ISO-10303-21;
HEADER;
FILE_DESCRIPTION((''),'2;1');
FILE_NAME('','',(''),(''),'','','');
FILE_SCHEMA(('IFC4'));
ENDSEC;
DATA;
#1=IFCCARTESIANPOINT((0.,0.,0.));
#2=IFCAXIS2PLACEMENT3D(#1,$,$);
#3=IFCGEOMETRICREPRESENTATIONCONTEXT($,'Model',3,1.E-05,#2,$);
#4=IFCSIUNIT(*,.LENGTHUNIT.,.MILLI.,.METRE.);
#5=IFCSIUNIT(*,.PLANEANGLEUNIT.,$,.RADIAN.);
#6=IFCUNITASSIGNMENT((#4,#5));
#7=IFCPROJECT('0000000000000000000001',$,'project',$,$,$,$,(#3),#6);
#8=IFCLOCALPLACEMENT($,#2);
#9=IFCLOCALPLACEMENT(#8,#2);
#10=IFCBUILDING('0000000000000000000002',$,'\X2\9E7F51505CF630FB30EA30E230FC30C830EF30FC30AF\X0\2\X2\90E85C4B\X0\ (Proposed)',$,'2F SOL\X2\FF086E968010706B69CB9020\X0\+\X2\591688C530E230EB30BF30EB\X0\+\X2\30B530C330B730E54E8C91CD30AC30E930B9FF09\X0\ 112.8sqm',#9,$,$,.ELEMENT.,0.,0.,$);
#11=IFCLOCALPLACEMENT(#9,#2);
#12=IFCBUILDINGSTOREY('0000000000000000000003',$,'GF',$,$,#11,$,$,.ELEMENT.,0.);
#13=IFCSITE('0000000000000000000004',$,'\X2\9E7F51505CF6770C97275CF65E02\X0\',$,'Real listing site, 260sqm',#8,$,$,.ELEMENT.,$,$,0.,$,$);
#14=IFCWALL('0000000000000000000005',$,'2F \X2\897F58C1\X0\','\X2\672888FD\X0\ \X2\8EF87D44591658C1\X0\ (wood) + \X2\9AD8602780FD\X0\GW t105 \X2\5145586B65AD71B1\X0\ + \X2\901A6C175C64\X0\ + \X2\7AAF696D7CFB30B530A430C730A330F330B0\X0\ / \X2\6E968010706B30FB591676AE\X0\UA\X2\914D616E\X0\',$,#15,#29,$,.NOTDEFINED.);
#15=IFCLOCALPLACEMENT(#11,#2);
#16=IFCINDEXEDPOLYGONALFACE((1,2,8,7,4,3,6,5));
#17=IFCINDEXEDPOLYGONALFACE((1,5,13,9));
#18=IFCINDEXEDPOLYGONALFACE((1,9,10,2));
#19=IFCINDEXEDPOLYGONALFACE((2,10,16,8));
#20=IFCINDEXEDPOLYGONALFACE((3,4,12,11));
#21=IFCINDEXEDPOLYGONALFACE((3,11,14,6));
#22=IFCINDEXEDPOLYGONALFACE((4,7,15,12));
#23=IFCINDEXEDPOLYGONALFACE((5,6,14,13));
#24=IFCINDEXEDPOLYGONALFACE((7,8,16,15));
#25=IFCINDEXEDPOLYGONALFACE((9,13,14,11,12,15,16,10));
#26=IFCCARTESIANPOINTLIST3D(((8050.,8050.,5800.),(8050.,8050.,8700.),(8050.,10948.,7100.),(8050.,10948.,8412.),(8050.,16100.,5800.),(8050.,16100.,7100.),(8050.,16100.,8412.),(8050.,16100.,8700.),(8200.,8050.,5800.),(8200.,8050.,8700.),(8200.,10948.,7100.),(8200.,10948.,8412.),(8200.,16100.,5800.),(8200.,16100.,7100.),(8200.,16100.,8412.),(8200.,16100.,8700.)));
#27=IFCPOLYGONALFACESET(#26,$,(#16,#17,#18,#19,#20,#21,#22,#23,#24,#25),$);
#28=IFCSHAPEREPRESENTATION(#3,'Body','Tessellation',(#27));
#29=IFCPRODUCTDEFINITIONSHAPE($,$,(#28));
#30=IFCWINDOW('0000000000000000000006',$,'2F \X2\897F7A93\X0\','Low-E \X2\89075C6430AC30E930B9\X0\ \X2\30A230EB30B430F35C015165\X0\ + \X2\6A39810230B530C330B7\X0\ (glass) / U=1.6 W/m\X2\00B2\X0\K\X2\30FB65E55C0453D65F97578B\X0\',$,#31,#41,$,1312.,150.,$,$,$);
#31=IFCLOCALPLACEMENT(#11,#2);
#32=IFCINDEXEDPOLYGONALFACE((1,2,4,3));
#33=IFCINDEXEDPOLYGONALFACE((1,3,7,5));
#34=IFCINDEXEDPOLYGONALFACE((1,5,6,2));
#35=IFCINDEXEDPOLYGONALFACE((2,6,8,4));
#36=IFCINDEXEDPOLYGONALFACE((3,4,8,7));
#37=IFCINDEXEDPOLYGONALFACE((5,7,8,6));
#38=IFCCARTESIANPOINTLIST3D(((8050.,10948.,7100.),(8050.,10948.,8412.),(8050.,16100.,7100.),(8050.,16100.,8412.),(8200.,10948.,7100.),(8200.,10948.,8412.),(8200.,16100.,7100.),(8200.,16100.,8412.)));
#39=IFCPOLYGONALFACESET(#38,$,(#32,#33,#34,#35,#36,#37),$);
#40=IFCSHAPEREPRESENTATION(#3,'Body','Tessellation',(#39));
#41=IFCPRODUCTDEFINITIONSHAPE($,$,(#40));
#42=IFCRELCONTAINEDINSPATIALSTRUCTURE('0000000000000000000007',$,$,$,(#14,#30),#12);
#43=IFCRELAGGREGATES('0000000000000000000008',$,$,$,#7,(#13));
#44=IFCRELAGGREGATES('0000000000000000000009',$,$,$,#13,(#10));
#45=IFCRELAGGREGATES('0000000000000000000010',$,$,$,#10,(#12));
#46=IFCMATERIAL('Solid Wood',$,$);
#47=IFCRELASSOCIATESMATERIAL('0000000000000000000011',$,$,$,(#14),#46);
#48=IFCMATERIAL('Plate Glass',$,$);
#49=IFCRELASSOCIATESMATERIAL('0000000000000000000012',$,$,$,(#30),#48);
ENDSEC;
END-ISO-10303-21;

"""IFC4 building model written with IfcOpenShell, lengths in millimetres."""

from ifc_helpers import new_model, si_unit, frame, frame_2d, origin, place, context, project, spatial, rectangle, extrude, material, element, fill, save


model = new_model("IFC4")

# Units and contexts
model_context = context("Model", 3, precision=1e-05, world=origin())
ifc_project = project(units=[si_unit("LENGTHUNIT", "METRE", prefix="MILLI"), si_unit("PLANEANGLEUNIT", "RADIAN")], contexts=[model_context])

# Site, building, storey
site_placement = place(None, origin())
site = spatial("IfcSite", under=ifc_project, at=site_placement, Name="鹿児島県霧島市", ObjectType="Real listing site, 260sqm", CompositionType="ELEMENT", RefElevation=0.0)
building_placement = place(site_placement, origin())
building = spatial("IfcBuilding", under=site, at=building_placement, Name="鹿児島・リモートワーク2部屋 (Proposed)", ObjectType="2F SOL（準耐火構造+外装モルタル+サッシュ二重ガラス） 112.8sqm", CompositionType="ELEMENT", ElevationOfRefHeight=0.0, ElevationOfTerrain=0.0)
storey_placement = place(building_placement, origin())
storey = spatial("IfcBuildingStorey", under=building, at=storey_placement, Name="GF", CompositionType="ELEMENT", Elevation=0.0)

# Shared definitions
ifc_material_1 = material(Name="Solid Wood")

# Shared definitions
ifc_material_2 = material(Name="Plate Glass")

# Wall, opening, window
wall_1_placement = place(storey_placement, frame((4025.0, 4025.0, 2900.0)))
wall_1 = element("IfcWall", 1, at=wall_1_placement, inside=storey, material=ifc_material_1, Name="2F 西壁", Description="木製 軸組外壁 (wood) + 高性能GW t105 充填断熱 + 通気層 + 窯業系サイディング / 準耐火・外皮UA配慮", PredefinedType="NOTDEFINED", context=model_context, shape_type="SweptSolid", body=[
    extrude(rectangle(XDim=150.0, YDim=8050.0, at=frame_2d((75.0, 4025.0))), frame((4025.0, 4025.0, 2900.0)), (0.0, 0.0, 1.0), 2900.0),
])
opening_1_placement = place(storey_placement, frame((4025.0, 5474.0, 3550.0)))
opening_1 = element("IfcOpeningElement", 2, at=opening_1_placement, cuts=wall_1, PredefinedType="NOTDEFINED", context=model_context, shape_type="SweptSolid", body=[
    extrude(rectangle(XDim=150.0, YDim=5152.0, at=frame_2d((75.0, 2576.0))), frame((4025.0, 5474.0, 3550.0)), (0.0, 0.0, 1.0), 1312.0),
])
window_1_placement = place(storey_placement, frame((4025.0, 5474.0, 3550.0)))
window_1 = element("IfcWindow", 3, at=window_1_placement, inside=storey, material=ifc_material_2, Name="2F 西窓", Description="Low-E 複層ガラス アルゴン封入 + 樹脂サッシ (glass) / U=1.6 W/m²K・日射取得型", OverallHeight=1312.0, OverallWidth=150.0, context=model_context, shape_type="SweptSolid", body=[
    extrude(rectangle(XDim=150.0, YDim=5152.0, at=frame_2d((75.0, 2576.0))), frame((4025.0, 5474.0, 3550.0)), (0.0, 0.0, 1.0), 1312.0),
])
fill(opening_1, window_1)

save(model, "model.ifc")
